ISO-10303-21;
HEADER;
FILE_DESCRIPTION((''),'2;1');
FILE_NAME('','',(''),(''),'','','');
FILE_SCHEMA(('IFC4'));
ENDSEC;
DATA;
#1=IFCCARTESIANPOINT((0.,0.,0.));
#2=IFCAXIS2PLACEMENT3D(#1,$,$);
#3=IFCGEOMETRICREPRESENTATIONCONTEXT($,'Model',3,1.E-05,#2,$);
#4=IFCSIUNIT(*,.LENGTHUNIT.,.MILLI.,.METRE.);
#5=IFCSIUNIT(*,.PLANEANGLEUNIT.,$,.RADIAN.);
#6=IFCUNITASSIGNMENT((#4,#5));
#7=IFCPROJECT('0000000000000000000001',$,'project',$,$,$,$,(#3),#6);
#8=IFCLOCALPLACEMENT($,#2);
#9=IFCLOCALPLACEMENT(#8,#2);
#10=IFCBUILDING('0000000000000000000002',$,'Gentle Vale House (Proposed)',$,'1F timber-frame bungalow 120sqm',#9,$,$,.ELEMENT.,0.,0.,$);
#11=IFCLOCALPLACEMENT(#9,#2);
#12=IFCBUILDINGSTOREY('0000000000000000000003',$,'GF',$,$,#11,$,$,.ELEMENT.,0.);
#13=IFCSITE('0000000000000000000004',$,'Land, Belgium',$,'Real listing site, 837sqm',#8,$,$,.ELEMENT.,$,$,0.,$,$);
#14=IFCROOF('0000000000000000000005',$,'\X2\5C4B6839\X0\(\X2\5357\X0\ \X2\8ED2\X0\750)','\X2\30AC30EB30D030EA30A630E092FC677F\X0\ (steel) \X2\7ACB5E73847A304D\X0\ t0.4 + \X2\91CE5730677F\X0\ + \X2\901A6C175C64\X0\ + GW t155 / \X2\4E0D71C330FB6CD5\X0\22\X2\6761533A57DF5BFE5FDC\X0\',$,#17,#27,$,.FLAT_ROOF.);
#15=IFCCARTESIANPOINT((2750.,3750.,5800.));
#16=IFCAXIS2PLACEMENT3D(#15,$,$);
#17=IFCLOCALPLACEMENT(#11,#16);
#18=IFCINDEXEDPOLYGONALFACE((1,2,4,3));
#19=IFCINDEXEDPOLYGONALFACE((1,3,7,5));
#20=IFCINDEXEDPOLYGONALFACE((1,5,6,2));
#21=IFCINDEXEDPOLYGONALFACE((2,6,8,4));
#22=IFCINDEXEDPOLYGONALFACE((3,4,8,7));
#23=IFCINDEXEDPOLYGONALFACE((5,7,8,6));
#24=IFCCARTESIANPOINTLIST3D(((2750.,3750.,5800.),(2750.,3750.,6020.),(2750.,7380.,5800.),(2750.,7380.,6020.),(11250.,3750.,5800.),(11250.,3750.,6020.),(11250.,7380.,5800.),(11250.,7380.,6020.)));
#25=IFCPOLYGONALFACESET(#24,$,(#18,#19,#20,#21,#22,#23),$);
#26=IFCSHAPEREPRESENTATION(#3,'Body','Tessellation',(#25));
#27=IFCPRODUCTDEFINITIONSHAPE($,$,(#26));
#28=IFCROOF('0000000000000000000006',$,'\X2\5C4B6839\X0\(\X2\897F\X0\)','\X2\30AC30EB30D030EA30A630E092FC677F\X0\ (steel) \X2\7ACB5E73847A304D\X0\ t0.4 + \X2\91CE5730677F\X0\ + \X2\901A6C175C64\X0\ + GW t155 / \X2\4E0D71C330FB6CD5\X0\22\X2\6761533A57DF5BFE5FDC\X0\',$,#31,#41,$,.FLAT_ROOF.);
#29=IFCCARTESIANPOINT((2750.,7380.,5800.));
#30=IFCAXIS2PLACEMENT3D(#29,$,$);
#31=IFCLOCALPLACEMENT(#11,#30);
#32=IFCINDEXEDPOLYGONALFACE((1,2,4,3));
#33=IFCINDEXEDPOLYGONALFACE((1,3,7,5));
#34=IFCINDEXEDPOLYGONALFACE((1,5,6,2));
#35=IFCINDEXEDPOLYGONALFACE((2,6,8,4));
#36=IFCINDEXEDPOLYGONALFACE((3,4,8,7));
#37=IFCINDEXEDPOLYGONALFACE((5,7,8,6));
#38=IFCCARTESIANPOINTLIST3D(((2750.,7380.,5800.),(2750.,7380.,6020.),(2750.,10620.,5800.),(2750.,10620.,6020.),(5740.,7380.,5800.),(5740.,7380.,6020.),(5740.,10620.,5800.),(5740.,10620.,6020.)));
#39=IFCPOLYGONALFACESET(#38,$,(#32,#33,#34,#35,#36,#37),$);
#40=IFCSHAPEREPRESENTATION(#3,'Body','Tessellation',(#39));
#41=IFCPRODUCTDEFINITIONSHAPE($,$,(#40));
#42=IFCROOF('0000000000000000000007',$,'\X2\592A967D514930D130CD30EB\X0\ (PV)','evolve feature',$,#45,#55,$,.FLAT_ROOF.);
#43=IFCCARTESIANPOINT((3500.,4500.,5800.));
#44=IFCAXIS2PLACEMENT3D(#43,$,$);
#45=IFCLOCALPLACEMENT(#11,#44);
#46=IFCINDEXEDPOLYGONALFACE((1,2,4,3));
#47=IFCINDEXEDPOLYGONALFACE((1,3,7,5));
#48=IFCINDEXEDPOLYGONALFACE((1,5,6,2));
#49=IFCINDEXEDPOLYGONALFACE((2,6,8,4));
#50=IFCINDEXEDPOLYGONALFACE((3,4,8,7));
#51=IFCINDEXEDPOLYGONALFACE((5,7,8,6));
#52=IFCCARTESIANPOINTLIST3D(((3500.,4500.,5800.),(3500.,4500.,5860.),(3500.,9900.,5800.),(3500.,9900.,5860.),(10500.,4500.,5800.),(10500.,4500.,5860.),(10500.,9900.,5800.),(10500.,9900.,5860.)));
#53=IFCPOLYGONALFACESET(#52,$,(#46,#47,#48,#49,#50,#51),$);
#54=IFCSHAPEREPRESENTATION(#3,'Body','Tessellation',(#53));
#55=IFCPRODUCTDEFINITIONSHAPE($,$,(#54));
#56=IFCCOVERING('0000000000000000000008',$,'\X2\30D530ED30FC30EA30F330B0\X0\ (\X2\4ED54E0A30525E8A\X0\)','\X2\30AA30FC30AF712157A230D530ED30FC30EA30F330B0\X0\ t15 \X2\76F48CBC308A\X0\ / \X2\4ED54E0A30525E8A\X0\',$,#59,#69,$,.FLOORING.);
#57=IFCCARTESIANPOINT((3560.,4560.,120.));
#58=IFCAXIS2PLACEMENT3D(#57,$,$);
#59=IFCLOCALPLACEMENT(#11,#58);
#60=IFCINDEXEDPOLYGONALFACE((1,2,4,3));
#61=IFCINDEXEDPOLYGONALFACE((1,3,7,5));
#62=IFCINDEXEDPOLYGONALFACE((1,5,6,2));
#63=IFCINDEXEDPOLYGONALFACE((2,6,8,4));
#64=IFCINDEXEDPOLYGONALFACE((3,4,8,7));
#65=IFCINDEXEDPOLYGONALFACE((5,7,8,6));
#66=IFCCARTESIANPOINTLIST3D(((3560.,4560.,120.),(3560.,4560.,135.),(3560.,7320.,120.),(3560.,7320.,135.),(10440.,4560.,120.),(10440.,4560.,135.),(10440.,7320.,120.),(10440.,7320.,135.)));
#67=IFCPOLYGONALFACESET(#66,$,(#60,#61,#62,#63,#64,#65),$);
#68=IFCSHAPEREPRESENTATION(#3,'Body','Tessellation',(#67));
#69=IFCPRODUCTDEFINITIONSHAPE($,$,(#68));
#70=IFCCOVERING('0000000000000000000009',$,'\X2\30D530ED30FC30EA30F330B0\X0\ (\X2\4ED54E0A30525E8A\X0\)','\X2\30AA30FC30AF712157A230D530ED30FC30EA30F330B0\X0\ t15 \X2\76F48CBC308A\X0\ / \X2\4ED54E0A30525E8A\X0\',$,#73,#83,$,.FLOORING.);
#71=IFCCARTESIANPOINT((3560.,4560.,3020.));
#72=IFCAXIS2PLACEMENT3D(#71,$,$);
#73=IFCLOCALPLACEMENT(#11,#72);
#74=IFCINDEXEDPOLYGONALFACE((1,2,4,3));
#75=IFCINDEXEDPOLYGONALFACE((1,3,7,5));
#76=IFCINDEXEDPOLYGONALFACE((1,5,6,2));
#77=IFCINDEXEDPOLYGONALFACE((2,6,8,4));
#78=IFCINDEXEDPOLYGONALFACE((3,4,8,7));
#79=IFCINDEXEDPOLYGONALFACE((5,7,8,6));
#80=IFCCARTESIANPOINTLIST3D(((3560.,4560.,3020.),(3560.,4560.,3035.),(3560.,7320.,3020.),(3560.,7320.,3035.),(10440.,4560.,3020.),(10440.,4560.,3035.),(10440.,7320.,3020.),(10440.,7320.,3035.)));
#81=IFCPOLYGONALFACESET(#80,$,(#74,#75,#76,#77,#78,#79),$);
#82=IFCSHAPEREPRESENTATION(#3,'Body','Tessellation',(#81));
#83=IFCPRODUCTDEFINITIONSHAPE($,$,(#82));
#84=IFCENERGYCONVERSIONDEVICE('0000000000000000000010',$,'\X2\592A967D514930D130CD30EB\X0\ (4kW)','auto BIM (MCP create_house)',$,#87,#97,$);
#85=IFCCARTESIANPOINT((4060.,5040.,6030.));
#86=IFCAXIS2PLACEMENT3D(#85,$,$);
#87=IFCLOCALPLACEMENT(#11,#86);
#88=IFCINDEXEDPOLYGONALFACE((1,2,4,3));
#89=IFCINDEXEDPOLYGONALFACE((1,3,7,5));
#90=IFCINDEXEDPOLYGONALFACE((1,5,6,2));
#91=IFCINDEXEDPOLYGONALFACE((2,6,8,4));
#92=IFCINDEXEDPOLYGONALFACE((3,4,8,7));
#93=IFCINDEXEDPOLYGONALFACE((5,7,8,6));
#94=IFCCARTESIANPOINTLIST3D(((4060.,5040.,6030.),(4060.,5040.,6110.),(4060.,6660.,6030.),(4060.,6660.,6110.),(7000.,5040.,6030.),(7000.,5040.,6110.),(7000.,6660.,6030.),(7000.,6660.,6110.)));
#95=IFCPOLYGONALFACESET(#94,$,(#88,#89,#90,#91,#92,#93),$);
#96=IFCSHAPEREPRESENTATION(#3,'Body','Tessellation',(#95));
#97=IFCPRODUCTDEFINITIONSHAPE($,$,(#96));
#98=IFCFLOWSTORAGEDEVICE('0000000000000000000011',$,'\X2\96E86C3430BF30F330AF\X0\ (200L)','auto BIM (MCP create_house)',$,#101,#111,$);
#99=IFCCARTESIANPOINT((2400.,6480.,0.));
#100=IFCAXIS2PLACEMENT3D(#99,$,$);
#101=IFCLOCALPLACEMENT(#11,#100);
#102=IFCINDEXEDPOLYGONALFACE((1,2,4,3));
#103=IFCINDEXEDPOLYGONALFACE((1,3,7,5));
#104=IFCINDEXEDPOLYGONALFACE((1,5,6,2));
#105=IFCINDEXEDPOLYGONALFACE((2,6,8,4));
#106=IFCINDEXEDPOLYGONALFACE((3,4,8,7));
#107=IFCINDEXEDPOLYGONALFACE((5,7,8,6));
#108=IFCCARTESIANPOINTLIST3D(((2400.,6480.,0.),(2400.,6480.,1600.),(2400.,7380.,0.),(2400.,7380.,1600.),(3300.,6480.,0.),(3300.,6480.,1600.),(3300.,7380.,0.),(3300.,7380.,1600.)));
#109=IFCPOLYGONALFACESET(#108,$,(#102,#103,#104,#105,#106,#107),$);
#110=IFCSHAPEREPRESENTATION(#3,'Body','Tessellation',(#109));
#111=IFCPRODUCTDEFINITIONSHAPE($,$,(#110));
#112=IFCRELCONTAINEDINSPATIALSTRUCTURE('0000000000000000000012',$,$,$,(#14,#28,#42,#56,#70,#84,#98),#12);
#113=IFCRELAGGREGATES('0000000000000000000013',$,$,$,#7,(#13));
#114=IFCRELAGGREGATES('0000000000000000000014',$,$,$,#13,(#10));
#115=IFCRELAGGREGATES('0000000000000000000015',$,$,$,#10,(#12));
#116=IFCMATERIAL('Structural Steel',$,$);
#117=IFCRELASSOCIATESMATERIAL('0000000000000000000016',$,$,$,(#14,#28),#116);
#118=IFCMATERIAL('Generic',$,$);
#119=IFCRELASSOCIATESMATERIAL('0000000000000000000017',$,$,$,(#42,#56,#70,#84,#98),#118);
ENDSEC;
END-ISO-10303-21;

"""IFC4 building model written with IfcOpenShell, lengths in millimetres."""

from ifc_helpers import new_model, si_unit, frame, frame_2d, origin, place, context, project, spatial, rectangle, extrude, material, element, save


model = new_model("IFC4")

# Units and contexts
model_context = context("Model", 3, precision=1e-05, world=origin())
ifc_project = project(units=[si_unit("LENGTHUNIT", "METRE", prefix="MILLI"), si_unit("PLANEANGLEUNIT", "RADIAN")], contexts=[model_context])

# Site, building, storey
site_placement = place(None, origin())
site = spatial("IfcSite", under=ifc_project, at=site_placement, Name="Land, Belgium", ObjectType="Real listing site, 837sqm", CompositionType="ELEMENT", RefElevation=0.0)
building_placement = place(site_placement, origin())
building = spatial("IfcBuilding", under=site, at=building_placement, Name="Gentle Vale House (Proposed)", ObjectType="1F timber-frame bungalow 120sqm", CompositionType="ELEMENT", ElevationOfRefHeight=0.0, ElevationOfTerrain=0.0)
storey_placement = place(building_placement, origin())
storey = spatial("IfcBuildingStorey", under=building, at=storey_placement, Name="GF", CompositionType="ELEMENT", Elevation=0.0)

# Shared definitions
ifc_material_1 = material(Name="Generic")

# Roofs
ifc_material_2 = material(Name="Structural Steel")
roof_1_placement = place(storey_placement, frame((2750.0, 3750.0, 5800.0)))
element("IfcRoof", 1, at=roof_1_placement, inside=storey, material=ifc_material_2, Name="屋根(南 軒750)", Description="ガルバリウム鋼板 (steel) 立平葺き t0.4 + 野地板 + 通気層 + GW t155 / 不燃・法22条区域対応", PredefinedType="FLAT_ROOF", context=model_context, shape_type="SweptSolid", body=[
    extrude(rectangle(XDim=8500.0, YDim=3630.0, at=frame_2d((4250.0, 1815.0))), frame((2750.0, 3750.0, 5800.0)), (0.0, 0.0, 1.0), 220.0),
])
roof_2_placement = place(storey_placement, frame((2750.0, 7380.0, 5800.0)))
element("IfcRoof", 2, at=roof_2_placement, inside=storey, material=ifc_material_2, Name="屋根(西)", Description="ガルバリウム鋼板 (steel) 立平葺き t0.4 + 野地板 + 通気層 + GW t155 / 不燃・法22条区域対応", PredefinedType="FLAT_ROOF", context=model_context, shape_type="SweptSolid", body=[
    extrude(rectangle(XDim=2990.0, YDim=3240.0, at=frame_2d((1495.0, 1620.0))), frame((2750.0, 7380.0, 5800.0)), (0.0, 0.0, 1.0), 220.0),
])
roof_3_placement = place(storey_placement, frame((3500.0, 4500.0, 5800.0)))
element("IfcRoof", 3, at=roof_3_placement, inside=storey, material=ifc_material_1, Name="太陽光パネル (PV)", Description="evolve feature", PredefinedType="FLAT_ROOF", context=model_context, shape_type="SweptSolid", body=[
    extrude(rectangle(XDim=7000.0, YDim=5400.0, at=frame_2d((3500.0, 2700.0))), frame((3500.0, 4500.0, 5800.0)), (0.0, 0.0, 1.0), 60.0),
])

# Coverings
covering_1_placement = place(storey_placement, frame((3560.0, 4560.0, 120.0)))
element("IfcCovering", 4, at=covering_1_placement, inside=storey, material=ifc_material_1, Name="フローリング (仕上げ床)", Description="オーク無垢フローリング t15 直貼り / 仕上げ床", PredefinedType="FLOORING", context=model_context, shape_type="SweptSolid", body=[
    extrude(rectangle(XDim=6880.0, YDim=2760.0, at=frame_2d((3440.0, 1380.0))), frame((3560.0, 4560.0, 120.0)), (0.0, 0.0, 1.0), 15.0),
])
covering_2_placement = place(storey_placement, frame((3560.0, 4560.0, 3020.0)))
element("IfcCovering", 5, at=covering_2_placement, inside=storey, material=ifc_material_1, Name="フローリング (仕上げ床)", Description="オーク無垢フローリング t15 直貼り / 仕上げ床", PredefinedType="FLOORING", context=model_context, shape_type="SweptSolid", body=[
    extrude(rectangle(XDim=6880.0, YDim=2760.0, at=frame_2d((3440.0, 1380.0))), frame((3560.0, 4560.0, 3020.0)), (0.0, 0.0, 1.0), 15.0),
])

# Energy conversion device
energy_conversion_device_placement = place(storey_placement, frame((4060.0, 5040.0, 6030.0)))
element("IfcEnergyConversionDevice", 6, at=energy_conversion_device_placement, inside=storey, material=ifc_material_1, Name="太陽光パネル (4kW)", Description="auto BIM (MCP create_house)", context=model_context, shape_type="SweptSolid", body=[
    extrude(rectangle(XDim=2940.0, YDim=1620.0, at=frame_2d((1470.0, 810.0))), frame((4060.0, 5040.0, 6030.0)), (0.0, 0.0, 1.0), 80.0),
])

# Flow storage device
flow_storage_device_placement = place(storey_placement, frame((2400.0, 6480.0, 0.0)))
element("IfcFlowStorageDevice", 7, at=flow_storage_device_placement, inside=storey, material=ifc_material_1, Name="雨水タンク (200L)", Description="auto BIM (MCP create_house)", context=model_context, shape_type="SweptSolid", body=[
    extrude(rectangle(XDim=900.0, YDim=900.0, at=frame_2d((450.0, 450.0))), frame((2400.0, 6480.0, 0.0)), (0.0, 0.0, 1.0), 1600.0),
])

save(model, "model.ifc")
